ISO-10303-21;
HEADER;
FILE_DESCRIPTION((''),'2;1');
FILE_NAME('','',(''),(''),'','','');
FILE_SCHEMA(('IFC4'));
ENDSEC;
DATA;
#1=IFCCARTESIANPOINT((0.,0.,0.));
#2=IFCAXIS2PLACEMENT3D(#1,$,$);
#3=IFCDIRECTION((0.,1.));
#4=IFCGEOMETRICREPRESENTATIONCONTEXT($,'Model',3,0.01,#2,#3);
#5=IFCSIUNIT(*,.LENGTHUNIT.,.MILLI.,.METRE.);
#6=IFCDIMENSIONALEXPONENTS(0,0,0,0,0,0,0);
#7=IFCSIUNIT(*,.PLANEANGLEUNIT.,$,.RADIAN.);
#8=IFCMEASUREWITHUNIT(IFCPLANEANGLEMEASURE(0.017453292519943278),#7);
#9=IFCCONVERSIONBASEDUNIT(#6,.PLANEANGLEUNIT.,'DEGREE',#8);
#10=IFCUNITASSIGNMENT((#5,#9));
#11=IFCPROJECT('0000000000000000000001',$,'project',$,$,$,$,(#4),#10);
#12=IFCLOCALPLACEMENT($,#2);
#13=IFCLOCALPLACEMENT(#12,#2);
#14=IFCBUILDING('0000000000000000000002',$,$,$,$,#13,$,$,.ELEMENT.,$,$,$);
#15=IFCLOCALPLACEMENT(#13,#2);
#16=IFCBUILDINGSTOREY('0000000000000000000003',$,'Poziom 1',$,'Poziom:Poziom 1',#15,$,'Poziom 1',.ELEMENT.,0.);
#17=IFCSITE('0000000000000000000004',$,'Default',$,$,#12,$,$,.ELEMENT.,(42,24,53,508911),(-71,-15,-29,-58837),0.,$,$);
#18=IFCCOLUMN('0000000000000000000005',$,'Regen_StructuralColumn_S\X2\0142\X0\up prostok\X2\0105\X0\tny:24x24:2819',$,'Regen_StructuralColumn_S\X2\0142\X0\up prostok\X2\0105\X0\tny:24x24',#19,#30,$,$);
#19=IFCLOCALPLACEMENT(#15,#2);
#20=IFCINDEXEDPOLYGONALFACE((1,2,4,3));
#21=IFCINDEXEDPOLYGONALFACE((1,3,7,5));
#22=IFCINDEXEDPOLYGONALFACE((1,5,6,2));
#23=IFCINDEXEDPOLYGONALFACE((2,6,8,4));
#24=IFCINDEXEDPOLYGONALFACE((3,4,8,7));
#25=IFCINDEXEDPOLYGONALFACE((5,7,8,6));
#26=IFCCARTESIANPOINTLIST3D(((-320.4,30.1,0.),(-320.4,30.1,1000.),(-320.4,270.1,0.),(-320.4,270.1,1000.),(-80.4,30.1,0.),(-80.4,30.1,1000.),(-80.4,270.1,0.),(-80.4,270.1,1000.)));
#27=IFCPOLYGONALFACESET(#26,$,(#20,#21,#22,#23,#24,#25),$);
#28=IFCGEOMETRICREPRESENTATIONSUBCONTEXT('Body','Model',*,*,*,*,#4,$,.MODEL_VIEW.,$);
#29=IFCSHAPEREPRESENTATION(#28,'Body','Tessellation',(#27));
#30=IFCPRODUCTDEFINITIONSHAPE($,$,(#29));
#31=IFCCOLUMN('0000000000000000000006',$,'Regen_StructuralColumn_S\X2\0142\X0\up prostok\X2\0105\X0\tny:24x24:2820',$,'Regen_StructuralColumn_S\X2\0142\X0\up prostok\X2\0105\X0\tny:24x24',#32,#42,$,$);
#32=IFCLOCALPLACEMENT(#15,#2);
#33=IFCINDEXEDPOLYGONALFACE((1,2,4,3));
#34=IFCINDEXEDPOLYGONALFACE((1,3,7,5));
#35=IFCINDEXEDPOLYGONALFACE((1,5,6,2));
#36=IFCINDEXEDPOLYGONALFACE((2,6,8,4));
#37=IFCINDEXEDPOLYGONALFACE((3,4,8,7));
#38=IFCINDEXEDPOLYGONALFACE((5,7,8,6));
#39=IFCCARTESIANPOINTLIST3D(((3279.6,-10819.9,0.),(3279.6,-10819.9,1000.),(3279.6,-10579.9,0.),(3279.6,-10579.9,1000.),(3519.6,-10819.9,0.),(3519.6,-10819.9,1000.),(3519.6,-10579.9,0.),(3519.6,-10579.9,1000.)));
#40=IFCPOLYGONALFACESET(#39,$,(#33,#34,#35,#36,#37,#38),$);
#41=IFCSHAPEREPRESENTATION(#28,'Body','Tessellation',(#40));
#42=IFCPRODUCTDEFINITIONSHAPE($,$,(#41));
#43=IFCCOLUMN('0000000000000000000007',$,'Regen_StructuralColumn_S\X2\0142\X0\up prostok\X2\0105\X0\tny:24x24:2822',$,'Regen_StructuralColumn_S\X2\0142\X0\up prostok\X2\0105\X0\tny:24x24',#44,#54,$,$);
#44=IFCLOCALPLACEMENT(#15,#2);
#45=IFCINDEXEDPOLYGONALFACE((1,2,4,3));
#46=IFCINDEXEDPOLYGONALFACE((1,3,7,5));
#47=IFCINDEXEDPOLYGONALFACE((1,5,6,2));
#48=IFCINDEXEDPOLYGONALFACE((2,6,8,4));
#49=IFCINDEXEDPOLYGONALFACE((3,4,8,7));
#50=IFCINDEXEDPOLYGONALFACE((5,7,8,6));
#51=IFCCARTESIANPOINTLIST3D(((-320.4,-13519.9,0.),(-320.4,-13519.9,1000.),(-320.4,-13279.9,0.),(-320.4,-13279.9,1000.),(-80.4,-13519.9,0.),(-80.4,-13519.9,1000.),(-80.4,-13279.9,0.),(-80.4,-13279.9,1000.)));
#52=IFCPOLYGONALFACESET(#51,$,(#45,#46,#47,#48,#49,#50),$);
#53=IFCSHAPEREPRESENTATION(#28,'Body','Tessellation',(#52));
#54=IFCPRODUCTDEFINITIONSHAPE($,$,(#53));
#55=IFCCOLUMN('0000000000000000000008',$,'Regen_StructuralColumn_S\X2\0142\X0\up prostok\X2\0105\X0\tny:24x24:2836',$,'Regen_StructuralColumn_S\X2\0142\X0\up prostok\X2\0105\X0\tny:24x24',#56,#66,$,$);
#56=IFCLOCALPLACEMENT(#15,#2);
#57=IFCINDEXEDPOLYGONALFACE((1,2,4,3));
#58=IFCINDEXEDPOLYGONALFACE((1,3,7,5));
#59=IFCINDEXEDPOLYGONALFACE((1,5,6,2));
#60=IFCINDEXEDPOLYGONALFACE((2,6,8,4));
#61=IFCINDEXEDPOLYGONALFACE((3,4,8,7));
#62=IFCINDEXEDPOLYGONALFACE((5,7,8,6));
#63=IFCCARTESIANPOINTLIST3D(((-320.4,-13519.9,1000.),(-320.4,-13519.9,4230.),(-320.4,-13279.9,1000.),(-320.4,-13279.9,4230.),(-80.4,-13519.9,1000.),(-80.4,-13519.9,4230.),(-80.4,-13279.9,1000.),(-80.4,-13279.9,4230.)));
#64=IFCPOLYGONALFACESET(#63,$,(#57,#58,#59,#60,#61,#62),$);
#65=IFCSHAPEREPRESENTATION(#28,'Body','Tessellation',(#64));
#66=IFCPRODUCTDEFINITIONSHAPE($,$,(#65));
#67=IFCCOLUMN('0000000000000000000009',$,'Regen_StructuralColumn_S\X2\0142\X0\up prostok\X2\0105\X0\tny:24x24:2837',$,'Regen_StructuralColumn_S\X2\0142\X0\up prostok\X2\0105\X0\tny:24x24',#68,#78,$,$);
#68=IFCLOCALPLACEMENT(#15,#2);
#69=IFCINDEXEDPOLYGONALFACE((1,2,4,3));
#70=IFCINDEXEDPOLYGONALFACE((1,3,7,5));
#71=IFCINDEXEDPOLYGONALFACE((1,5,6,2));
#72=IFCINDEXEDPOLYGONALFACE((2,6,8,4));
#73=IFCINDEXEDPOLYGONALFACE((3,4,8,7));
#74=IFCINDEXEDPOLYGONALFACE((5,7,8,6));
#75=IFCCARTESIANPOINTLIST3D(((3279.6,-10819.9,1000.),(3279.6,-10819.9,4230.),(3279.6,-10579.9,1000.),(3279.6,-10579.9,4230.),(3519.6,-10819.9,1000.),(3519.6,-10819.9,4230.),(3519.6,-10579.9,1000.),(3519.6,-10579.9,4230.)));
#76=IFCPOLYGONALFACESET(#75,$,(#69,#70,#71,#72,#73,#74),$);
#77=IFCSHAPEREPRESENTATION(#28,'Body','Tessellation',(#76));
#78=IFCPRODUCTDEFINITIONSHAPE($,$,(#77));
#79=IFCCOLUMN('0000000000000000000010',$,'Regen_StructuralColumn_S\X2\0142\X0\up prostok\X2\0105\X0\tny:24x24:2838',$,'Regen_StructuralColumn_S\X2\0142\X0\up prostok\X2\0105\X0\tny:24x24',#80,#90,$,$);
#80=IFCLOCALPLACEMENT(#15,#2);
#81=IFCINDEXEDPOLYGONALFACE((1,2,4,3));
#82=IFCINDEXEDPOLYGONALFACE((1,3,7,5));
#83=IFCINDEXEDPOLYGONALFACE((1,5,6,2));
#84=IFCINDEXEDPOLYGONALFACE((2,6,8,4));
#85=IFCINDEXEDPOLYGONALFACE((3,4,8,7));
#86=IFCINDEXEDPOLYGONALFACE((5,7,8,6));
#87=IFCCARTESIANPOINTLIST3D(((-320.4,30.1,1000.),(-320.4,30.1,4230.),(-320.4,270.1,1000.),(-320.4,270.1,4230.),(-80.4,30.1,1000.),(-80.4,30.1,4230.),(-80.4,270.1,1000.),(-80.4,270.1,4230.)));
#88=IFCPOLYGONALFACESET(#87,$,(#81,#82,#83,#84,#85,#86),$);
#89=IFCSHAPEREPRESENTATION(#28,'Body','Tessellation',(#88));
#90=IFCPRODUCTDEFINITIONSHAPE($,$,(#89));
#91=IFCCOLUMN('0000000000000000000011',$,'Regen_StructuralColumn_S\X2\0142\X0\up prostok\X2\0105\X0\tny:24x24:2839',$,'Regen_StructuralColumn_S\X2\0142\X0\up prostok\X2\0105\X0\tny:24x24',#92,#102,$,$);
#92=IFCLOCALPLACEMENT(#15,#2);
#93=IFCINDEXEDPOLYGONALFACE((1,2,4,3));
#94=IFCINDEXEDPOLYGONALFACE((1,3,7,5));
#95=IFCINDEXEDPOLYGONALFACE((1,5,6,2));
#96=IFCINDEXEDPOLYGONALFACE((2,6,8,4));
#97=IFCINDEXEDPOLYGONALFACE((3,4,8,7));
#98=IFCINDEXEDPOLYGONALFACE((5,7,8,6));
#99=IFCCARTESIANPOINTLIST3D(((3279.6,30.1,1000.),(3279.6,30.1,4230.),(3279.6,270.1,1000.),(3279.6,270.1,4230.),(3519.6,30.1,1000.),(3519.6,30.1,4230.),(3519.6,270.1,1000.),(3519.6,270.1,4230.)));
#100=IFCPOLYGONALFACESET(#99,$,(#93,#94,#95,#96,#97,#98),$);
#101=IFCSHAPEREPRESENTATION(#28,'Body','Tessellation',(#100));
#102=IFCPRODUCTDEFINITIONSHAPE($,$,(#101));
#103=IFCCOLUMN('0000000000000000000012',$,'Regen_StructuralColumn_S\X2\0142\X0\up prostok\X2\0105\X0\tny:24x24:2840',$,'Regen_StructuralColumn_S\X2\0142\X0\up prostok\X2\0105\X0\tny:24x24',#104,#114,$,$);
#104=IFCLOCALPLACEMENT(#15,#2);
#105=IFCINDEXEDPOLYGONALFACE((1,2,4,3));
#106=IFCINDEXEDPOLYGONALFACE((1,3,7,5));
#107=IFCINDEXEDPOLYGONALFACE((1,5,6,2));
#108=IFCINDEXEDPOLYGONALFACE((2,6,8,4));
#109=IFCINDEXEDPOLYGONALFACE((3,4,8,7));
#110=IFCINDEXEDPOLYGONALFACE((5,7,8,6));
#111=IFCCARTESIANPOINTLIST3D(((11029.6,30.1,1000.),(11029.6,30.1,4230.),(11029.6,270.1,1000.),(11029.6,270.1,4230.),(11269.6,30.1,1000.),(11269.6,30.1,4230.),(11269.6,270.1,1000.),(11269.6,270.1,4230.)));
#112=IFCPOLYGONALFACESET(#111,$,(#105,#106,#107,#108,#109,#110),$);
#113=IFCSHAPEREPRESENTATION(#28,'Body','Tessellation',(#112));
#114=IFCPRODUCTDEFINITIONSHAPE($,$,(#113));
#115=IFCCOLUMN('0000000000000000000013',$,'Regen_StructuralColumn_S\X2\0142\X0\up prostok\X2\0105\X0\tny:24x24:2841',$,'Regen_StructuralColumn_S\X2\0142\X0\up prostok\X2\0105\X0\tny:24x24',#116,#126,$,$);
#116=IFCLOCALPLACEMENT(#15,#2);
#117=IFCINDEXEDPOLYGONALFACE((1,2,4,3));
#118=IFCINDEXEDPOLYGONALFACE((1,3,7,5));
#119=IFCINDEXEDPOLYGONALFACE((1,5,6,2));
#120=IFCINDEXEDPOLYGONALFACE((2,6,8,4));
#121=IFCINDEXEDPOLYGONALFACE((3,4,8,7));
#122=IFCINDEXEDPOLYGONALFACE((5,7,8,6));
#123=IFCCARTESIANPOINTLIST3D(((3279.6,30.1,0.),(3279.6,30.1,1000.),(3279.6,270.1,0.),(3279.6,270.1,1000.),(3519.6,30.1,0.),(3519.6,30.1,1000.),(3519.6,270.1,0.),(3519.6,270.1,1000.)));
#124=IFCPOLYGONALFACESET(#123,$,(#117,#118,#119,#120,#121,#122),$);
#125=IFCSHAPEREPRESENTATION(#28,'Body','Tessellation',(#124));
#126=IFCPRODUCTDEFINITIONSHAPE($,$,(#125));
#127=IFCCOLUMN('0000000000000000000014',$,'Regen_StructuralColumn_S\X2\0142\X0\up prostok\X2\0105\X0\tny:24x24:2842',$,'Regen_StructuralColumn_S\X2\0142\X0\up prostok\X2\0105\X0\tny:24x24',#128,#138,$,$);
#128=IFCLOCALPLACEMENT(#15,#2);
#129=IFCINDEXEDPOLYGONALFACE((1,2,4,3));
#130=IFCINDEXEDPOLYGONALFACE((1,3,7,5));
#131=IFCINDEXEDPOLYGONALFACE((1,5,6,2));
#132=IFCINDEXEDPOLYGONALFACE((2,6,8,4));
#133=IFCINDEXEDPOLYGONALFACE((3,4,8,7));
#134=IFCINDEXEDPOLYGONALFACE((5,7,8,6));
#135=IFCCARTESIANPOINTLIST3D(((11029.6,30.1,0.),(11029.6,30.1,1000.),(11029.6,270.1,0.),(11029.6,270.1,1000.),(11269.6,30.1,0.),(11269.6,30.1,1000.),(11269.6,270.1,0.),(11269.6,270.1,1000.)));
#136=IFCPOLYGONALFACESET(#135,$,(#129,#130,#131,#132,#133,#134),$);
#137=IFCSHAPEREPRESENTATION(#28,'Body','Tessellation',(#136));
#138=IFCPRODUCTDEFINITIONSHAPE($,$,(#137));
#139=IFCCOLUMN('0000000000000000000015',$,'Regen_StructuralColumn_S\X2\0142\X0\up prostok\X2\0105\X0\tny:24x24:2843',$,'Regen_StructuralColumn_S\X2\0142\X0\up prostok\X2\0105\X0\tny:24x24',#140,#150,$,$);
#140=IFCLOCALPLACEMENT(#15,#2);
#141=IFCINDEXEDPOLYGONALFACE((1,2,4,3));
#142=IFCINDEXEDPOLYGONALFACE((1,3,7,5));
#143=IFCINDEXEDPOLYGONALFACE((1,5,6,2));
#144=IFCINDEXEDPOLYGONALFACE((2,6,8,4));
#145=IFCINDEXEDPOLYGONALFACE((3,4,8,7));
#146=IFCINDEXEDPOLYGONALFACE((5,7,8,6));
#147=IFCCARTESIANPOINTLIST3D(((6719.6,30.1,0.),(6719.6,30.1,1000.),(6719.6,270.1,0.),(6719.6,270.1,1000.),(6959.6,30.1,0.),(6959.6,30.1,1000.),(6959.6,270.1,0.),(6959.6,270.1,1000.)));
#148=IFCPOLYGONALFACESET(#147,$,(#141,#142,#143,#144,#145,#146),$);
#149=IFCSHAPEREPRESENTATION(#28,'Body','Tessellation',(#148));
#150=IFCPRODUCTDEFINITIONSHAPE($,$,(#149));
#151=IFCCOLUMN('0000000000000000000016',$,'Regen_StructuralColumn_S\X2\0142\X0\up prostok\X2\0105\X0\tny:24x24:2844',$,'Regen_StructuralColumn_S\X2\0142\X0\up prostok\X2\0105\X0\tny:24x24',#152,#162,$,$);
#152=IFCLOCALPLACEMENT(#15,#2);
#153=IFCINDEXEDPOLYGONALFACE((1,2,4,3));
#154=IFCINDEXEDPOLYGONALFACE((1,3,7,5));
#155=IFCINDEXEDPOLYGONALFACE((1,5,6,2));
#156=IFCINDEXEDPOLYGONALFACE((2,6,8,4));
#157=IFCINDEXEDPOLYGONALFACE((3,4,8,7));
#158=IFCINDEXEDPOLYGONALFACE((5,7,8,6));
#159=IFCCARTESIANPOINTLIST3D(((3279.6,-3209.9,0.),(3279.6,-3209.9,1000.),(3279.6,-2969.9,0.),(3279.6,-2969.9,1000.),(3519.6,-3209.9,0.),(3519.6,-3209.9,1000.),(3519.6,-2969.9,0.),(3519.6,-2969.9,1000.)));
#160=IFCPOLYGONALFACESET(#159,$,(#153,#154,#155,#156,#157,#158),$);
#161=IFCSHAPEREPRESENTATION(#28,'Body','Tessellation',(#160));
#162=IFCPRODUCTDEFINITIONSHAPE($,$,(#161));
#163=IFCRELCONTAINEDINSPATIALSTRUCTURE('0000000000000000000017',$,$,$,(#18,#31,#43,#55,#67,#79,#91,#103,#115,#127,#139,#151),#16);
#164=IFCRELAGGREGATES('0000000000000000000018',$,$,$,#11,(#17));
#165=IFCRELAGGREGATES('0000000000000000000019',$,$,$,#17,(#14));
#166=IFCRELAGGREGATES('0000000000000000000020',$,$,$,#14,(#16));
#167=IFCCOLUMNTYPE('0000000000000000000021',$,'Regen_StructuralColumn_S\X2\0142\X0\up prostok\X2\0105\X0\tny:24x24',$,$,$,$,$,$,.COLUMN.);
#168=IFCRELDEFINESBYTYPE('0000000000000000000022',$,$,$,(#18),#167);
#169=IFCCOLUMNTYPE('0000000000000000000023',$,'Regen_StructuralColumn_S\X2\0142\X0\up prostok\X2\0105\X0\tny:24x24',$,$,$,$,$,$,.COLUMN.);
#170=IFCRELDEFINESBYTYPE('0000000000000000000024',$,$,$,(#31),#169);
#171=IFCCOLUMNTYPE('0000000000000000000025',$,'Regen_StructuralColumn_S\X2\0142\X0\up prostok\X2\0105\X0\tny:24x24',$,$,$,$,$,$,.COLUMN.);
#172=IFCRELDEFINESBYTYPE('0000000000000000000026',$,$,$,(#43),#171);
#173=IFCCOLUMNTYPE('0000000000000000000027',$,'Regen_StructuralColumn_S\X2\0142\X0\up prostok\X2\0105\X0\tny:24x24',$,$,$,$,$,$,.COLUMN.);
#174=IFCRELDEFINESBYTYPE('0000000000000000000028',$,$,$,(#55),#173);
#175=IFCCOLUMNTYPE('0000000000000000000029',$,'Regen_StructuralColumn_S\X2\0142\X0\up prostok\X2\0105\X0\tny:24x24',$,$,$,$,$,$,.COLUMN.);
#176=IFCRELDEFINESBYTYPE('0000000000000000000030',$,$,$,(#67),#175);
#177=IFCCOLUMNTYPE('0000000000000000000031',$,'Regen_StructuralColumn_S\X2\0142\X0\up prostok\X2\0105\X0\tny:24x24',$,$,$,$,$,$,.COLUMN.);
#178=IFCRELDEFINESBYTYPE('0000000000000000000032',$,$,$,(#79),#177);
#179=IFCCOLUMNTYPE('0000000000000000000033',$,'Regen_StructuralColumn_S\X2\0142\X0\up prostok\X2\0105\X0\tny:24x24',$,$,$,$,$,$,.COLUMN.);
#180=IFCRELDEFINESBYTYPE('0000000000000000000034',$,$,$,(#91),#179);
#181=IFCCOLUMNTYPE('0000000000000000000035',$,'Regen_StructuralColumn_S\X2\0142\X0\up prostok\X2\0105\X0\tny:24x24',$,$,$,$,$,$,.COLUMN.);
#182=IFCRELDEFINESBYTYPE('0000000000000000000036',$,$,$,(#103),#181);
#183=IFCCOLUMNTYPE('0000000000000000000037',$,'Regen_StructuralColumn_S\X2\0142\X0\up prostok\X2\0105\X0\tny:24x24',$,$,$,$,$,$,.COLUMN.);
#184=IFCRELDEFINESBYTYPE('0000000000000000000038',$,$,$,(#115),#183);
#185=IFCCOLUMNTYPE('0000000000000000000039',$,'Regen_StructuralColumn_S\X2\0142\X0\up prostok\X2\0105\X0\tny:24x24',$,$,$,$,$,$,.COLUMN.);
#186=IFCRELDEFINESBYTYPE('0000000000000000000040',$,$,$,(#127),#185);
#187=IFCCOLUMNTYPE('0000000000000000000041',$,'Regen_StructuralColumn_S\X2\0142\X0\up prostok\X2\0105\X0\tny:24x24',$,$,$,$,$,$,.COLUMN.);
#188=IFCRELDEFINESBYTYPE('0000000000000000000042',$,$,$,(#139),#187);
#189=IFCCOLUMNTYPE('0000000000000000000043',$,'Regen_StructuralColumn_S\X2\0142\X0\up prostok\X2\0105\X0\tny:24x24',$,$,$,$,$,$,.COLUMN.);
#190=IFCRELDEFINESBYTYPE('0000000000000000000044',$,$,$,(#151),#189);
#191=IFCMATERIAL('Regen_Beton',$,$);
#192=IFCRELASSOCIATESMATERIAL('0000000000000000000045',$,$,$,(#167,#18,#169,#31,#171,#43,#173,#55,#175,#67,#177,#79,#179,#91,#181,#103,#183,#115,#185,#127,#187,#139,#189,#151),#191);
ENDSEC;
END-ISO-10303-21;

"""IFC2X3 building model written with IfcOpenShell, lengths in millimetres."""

from ifc_helpers import new_model, entity, si_unit, converted_unit, direction, frame, frame_2d, origin, origin_2d_with_axis, place, context, subcontext, project, spatial, rectangle, extrude, source, transform, mapped, material, type_object, type_shapes, element, save


model = new_model("IFC2X3")

# Units and contexts
model_context = context("Model", 3, precision=0.01, world=origin(), true_north=direction((0.0, 1.0)))
body_context = subcontext(model_context, "Body", "Model", "MODEL_VIEW")
ifc_project = project(units=[si_unit("LENGTHUNIT", "METRE", prefix="MILLI"), converted_unit("PLANEANGLEUNIT", "DEGREE", entity("IfcPlaneAngleMeasure", 0.017453292519943278), si_unit("PLANEANGLEUNIT", "RADIAN"), dimensions=[0, 0, 0, 0, 0, 0, 0])], contexts=[model_context])

# Site, building, storey
site_placement = place(None, origin())
site = spatial("IfcSite", under=ifc_project, at=site_placement, Name="Default", CompositionType="ELEMENT", RefLatitude=(42, 24, 53, 508911), RefLongitude=(-71, -15, -29, -58837), RefElevation=0.0)
building_placement = place(site_placement, origin())
building = spatial("IfcBuilding", under=site, at=building_placement, CompositionType="ELEMENT")
storey_placement = place(building_placement, origin())
storey = spatial("IfcBuildingStorey", under=building, at=storey_placement, Name="Poziom 1", ObjectType="Poziom:Poziom 1", LongName="Poziom 1", CompositionType="ELEMENT", Elevation=0.0)

# Columns
ifc_material = material(Name="Regen_Beton")
column_type_1 = type_object("IfcColumnType", Name="Regen_StructuralColumn_Słup prostokątny:24x24", PredefinedType="COLUMN", material=ifc_material)
shared_shape_1 = source(origin(), body_context, "Body", "SweptSolid", [
    extrude(rectangle(XDim=240.0, YDim=240.0, at=origin_2d_with_axis()), frame((0.0, 0.0, 0.0), z_axis=(0.0, 0.0, 1.0), x_axis=(-1.0, 0.0, 0.0)), (0.0, 0.0, 1.0), 1000.0),
])
type_shapes(column_type_1, [shared_shape_1])
column_1_placement = place(storey_placement, frame((-200.4, 150.1, 0.0)))
element("IfcColumn", 1, at=column_1_placement, inside=storey, type_object=column_type_1, material=ifc_material, Name="Regen_StructuralColumn_Słup prostokątny:24x24:2819", ObjectType="Regen_StructuralColumn_Słup prostokątny:24x24", context=body_context, shape_type="MappedRepresentation", body=[
    mapped(shared_shape_1, transform((0.0, 0.0, 0.0), scale=1.0)),
])
column_type_2 = type_object("IfcColumnType", Name="Regen_StructuralColumn_Słup prostokątny:24x24", PredefinedType="COLUMN", material=ifc_material)
shared_shape_2 = source(origin(), body_context, "Body", "SweptSolid", [
    extrude(rectangle(XDim=240.0, YDim=240.0, at=frame_2d((0.0, 0.0), x_axis=(1.0, 0.0))), frame((3399.6, -10699.9, 0.0), z_axis=(0.0, 0.0, 1.0), x_axis=(-1.0, 0.0, 0.0)), (0.0, 0.0, 1.0), 1000.0),
])
type_shapes(column_type_2, [shared_shape_2])
column_2_placement = place(storey_placement, origin())
element("IfcColumn", 2, at=column_2_placement, inside=storey, type_object=column_type_2, material=ifc_material, Name="Regen_StructuralColumn_Słup prostokątny:24x24:2820", ObjectType="Regen_StructuralColumn_Słup prostokątny:24x24", context=body_context, shape_type="MappedRepresentation", body=[
    mapped(shared_shape_2, transform((0.0, 0.0, 0.0), scale=1.0)),
])
column_type_3 = type_object("IfcColumnType", Name="Regen_StructuralColumn_Słup prostokątny:24x24", PredefinedType="COLUMN", material=ifc_material)
shared_shape_3 = source(origin(), body_context, "Body", "SweptSolid", [
    extrude(rectangle(XDim=240.0, YDim=240.0, at=frame_2d((0.0, 0.0), x_axis=(1.0, 0.0))), frame((-200.4, -13399.9, 0.0), z_axis=(0.0, 0.0, 1.0), x_axis=(-1.0, 0.0, 0.0)), (0.0, 0.0, 1.0), 1000.0),
])
type_shapes(column_type_3, [shared_shape_3])
column_3_placement = place(storey_placement, origin())
element("IfcColumn", 3, at=column_3_placement, inside=storey, type_object=column_type_3, material=ifc_material, Name="Regen_StructuralColumn_Słup prostokątny:24x24:2822", ObjectType="Regen_StructuralColumn_Słup prostokątny:24x24", context=body_context, shape_type="MappedRepresentation", body=[
    mapped(shared_shape_3, transform((0.0, 0.0, 0.0), scale=1.0)),
])
column_type_4 = type_object("IfcColumnType", Name="Regen_StructuralColumn_Słup prostokątny:24x24", PredefinedType="COLUMN", material=ifc_material)
shared_shape_4 = source(origin(), body_context, "Body", "SweptSolid", [
    extrude(rectangle(XDim=240.0, YDim=240.0, at=frame_2d((0.0, 0.0), x_axis=(1.0, 0.0))), frame((-200.4, -13399.9, 1000.0), z_axis=(0.0, 0.0, 1.0), x_axis=(-1.0, 0.0, 0.0)), (0.0, 0.0, 1.0), 3230.0),
])
type_shapes(column_type_4, [shared_shape_4])
column_4_placement = place(storey_placement, origin())
element("IfcColumn", 4, at=column_4_placement, inside=storey, type_object=column_type_4, material=ifc_material, Name="Regen_StructuralColumn_Słup prostokątny:24x24:2836", ObjectType="Regen_StructuralColumn_Słup prostokątny:24x24", context=body_context, shape_type="MappedRepresentation", body=[
    mapped(shared_shape_4, transform((0.0, 0.0, 0.0), scale=1.0)),
])
column_type_5 = type_object("IfcColumnType", Name="Regen_StructuralColumn_Słup prostokątny:24x24", PredefinedType="COLUMN", material=ifc_material)
shared_shape_5 = source(origin(), body_context, "Body", "SweptSolid", [
    extrude(rectangle(XDim=240.0, YDim=240.0, at=frame_2d((0.0, 0.0), x_axis=(1.0, 0.0))), frame((3399.6, -10699.9, 1000.0), z_axis=(0.0, 0.0, 1.0), x_axis=(-1.0, 0.0, 0.0)), (0.0, 0.0, 1.0), 3230.0),
])
type_shapes(column_type_5, [shared_shape_5])
column_5_placement = place(storey_placement, origin())
element("IfcColumn", 5, at=column_5_placement, inside=storey, type_object=column_type_5, material=ifc_material, Name="Regen_StructuralColumn_Słup prostokątny:24x24:2837", ObjectType="Regen_StructuralColumn_Słup prostokątny:24x24", context=body_context, shape_type="MappedRepresentation", body=[
    mapped(shared_shape_5, transform((0.0, 0.0, 0.0), scale=1.0)),
])
column_type_6 = type_object("IfcColumnType", Name="Regen_StructuralColumn_Słup prostokątny:24x24", PredefinedType="COLUMN", material=ifc_material)
shared_shape_6 = source(origin(), body_context, "Body", "SweptSolid", [
    extrude(rectangle(XDim=240.0, YDim=240.0, at=origin_2d_with_axis()), frame((-200.4, 150.1, 1000.0), z_axis=(0.0, 0.0, 1.0), x_axis=(-1.0, 0.0, 0.0)), (0.0, 0.0, 1.0), 3230.0),
])
type_shapes(column_type_6, [shared_shape_6])
column_6_placement = place(storey_placement, origin())
element("IfcColumn", 6, at=column_6_placement, inside=storey, type_object=column_type_6, material=ifc_material, Name="Regen_StructuralColumn_Słup prostokątny:24x24:2838", ObjectType="Regen_StructuralColumn_Słup prostokątny:24x24", context=body_context, shape_type="MappedRepresentation", body=[
    mapped(shared_shape_6, transform((0.0, 0.0, 0.0), scale=1.0)),
])
column_type_7 = type_object("IfcColumnType", Name="Regen_StructuralColumn_Słup prostokątny:24x24", PredefinedType="COLUMN", material=ifc_material)
shared_shape_7 = source(origin(), body_context, "Body", "SweptSolid", [
    extrude(rectangle(XDim=240.0, YDim=240.0, at=frame_2d((0.0, 0.0), x_axis=(1.0, 0.0))), frame((3399.6, 150.1, 1000.0), z_axis=(0.0, 0.0, 1.0), x_axis=(-1.0, 0.0, 0.0)), (0.0, 0.0, 1.0), 3230.0),
])
type_shapes(column_type_7, [shared_shape_7])
column_7_placement = place(storey_placement, origin())
element("IfcColumn", 7, at=column_7_placement, inside=storey, type_object=column_type_7, material=ifc_material, Name="Regen_StructuralColumn_Słup prostokątny:24x24:2839", ObjectType="Regen_StructuralColumn_Słup prostokątny:24x24", context=body_context, shape_type="MappedRepresentation", body=[
    mapped(shared_shape_7, transform((0.0, 0.0, 0.0), scale=1.0)),
])
column_type_8 = type_object("IfcColumnType", Name="Regen_StructuralColumn_Słup prostokątny:24x24", PredefinedType="COLUMN", material=ifc_material)
shared_shape_8 = source(origin(), body_context, "Body", "SweptSolid", [
    extrude(rectangle(XDim=240.0, YDim=240.0, at=frame_2d((0.0, 0.0), x_axis=(1.0, 0.0))), frame((11149.6, 150.1, 1000.0), z_axis=(0.0, 0.0, 1.0), x_axis=(-1.0, 0.0, 0.0)), (0.0, 0.0, 1.0), 3230.0),
])
type_shapes(column_type_8, [shared_shape_8])
column_8_placement = place(storey_placement, origin())
element("IfcColumn", 8, at=column_8_placement, inside=storey, type_object=column_type_8, material=ifc_material, Name="Regen_StructuralColumn_Słup prostokątny:24x24:2840", ObjectType="Regen_StructuralColumn_Słup prostokątny:24x24", context=body_context, shape_type="MappedRepresentation", body=[
    mapped(shared_shape_8, transform((0.0, 0.0, 0.0), scale=1.0)),
])
column_type_9 = type_object("IfcColumnType", Name="Regen_StructuralColumn_Słup prostokątny:24x24", PredefinedType="COLUMN", material=ifc_material)
shared_shape_9 = source(origin(), body_context, "Body", "SweptSolid", [
    extrude(rectangle(XDim=240.0, YDim=240.0, at=frame_2d((0.0, 0.0), x_axis=(1.0, 0.0))), frame((3399.6, 150.1, 0.0), z_axis=(0.0, 0.0, 1.0), x_axis=(-1.0, 0.0, 0.0)), (0.0, 0.0, 1.0), 1000.0),
])
type_shapes(column_type_9, [shared_shape_9])
column_9_placement = place(storey_placement, origin())
element("IfcColumn", 9, at=column_9_placement, inside=storey, type_object=column_type_9, material=ifc_material, Name="Regen_StructuralColumn_Słup prostokątny:24x24:2841", ObjectType="Regen_StructuralColumn_Słup prostokątny:24x24", context=body_context, shape_type="MappedRepresentation", body=[
    mapped(shared_shape_9, transform((0.0, 0.0, 0.0), scale=1.0)),
])
column_type_10 = type_object("IfcColumnType", Name="Regen_StructuralColumn_Słup prostokątny:24x24", PredefinedType="COLUMN", material=ifc_material)
shared_shape_10 = source(origin(), body_context, "Body", "SweptSolid", [
    extrude(rectangle(XDim=240.0, YDim=240.0, at=frame_2d((0.0, 0.0), x_axis=(1.0, 0.0))), frame((11149.6, 150.1, 0.0), z_axis=(0.0, 0.0, 1.0), x_axis=(-1.0, 0.0, 0.0)), (0.0, 0.0, 1.0), 1000.0),
])
type_shapes(column_type_10, [shared_shape_10])
column_10_placement = place(storey_placement, origin())
element("IfcColumn", 10, at=column_10_placement, inside=storey, type_object=column_type_10, material=ifc_material, Name="Regen_StructuralColumn_Słup prostokątny:24x24:2842", ObjectType="Regen_StructuralColumn_Słup prostokątny:24x24", context=body_context, shape_type="MappedRepresentation", body=[
    mapped(shared_shape_10, transform((0.0, 0.0, 0.0), scale=1.0)),
])
column_type_11 = type_object("IfcColumnType", Name="Regen_StructuralColumn_Słup prostokątny:24x24", PredefinedType="COLUMN", material=ifc_material)
shared_shape_11 = source(origin(), body_context, "Body", "SweptSolid", [
    extrude(rectangle(XDim=240.0, YDim=240.0, at=origin_2d_with_axis()), frame((6839.6, 150.1, 0.0), z_axis=(0.0, 0.0, 1.0), x_axis=(-1.0, 0.0, 0.0)), (0.0, 0.0, 1.0), 1000.0),
])
type_shapes(column_type_11, [shared_shape_11])
column_11_placement = place(storey_placement, origin())
element("IfcColumn", 11, at=column_11_placement, inside=storey, type_object=column_type_11, material=ifc_material, Name="Regen_StructuralColumn_Słup prostokątny:24x24:2843", ObjectType="Regen_StructuralColumn_Słup prostokątny:24x24", context=body_context, shape_type="MappedRepresentation", body=[
    mapped(shared_shape_11, transform((0.0, 0.0, 0.0), scale=1.0)),
])
column_type_12 = type_object("IfcColumnType", Name="Regen_StructuralColumn_Słup prostokątny:24x24", PredefinedType="COLUMN", material=ifc_material)
shared_shape_12 = source(origin(), body_context, "Body", "SweptSolid", [
    extrude(rectangle(XDim=240.0, YDim=240.0, at=frame_2d((0.0, 0.0), x_axis=(1.0, 0.0))), frame((3399.6, -3089.9, 0.0), z_axis=(0.0, 0.0, 1.0), x_axis=(-1.0, 0.0, 0.0)), (0.0, 0.0, 1.0), 1000.0),
])
type_shapes(column_type_12, [shared_shape_12])
column_12_placement = place(storey_placement, origin())
element("IfcColumn", 12, at=column_12_placement, inside=storey, type_object=column_type_12, material=ifc_material, Name="Regen_StructuralColumn_Słup prostokątny:24x24:2844", ObjectType="Regen_StructuralColumn_Słup prostokątny:24x24", context=body_context, shape_type="MappedRepresentation", body=[
    mapped(shared_shape_12, transform((0.0, 0.0, 0.0), scale=1.0)),
])

save(model, "model.ifc")
